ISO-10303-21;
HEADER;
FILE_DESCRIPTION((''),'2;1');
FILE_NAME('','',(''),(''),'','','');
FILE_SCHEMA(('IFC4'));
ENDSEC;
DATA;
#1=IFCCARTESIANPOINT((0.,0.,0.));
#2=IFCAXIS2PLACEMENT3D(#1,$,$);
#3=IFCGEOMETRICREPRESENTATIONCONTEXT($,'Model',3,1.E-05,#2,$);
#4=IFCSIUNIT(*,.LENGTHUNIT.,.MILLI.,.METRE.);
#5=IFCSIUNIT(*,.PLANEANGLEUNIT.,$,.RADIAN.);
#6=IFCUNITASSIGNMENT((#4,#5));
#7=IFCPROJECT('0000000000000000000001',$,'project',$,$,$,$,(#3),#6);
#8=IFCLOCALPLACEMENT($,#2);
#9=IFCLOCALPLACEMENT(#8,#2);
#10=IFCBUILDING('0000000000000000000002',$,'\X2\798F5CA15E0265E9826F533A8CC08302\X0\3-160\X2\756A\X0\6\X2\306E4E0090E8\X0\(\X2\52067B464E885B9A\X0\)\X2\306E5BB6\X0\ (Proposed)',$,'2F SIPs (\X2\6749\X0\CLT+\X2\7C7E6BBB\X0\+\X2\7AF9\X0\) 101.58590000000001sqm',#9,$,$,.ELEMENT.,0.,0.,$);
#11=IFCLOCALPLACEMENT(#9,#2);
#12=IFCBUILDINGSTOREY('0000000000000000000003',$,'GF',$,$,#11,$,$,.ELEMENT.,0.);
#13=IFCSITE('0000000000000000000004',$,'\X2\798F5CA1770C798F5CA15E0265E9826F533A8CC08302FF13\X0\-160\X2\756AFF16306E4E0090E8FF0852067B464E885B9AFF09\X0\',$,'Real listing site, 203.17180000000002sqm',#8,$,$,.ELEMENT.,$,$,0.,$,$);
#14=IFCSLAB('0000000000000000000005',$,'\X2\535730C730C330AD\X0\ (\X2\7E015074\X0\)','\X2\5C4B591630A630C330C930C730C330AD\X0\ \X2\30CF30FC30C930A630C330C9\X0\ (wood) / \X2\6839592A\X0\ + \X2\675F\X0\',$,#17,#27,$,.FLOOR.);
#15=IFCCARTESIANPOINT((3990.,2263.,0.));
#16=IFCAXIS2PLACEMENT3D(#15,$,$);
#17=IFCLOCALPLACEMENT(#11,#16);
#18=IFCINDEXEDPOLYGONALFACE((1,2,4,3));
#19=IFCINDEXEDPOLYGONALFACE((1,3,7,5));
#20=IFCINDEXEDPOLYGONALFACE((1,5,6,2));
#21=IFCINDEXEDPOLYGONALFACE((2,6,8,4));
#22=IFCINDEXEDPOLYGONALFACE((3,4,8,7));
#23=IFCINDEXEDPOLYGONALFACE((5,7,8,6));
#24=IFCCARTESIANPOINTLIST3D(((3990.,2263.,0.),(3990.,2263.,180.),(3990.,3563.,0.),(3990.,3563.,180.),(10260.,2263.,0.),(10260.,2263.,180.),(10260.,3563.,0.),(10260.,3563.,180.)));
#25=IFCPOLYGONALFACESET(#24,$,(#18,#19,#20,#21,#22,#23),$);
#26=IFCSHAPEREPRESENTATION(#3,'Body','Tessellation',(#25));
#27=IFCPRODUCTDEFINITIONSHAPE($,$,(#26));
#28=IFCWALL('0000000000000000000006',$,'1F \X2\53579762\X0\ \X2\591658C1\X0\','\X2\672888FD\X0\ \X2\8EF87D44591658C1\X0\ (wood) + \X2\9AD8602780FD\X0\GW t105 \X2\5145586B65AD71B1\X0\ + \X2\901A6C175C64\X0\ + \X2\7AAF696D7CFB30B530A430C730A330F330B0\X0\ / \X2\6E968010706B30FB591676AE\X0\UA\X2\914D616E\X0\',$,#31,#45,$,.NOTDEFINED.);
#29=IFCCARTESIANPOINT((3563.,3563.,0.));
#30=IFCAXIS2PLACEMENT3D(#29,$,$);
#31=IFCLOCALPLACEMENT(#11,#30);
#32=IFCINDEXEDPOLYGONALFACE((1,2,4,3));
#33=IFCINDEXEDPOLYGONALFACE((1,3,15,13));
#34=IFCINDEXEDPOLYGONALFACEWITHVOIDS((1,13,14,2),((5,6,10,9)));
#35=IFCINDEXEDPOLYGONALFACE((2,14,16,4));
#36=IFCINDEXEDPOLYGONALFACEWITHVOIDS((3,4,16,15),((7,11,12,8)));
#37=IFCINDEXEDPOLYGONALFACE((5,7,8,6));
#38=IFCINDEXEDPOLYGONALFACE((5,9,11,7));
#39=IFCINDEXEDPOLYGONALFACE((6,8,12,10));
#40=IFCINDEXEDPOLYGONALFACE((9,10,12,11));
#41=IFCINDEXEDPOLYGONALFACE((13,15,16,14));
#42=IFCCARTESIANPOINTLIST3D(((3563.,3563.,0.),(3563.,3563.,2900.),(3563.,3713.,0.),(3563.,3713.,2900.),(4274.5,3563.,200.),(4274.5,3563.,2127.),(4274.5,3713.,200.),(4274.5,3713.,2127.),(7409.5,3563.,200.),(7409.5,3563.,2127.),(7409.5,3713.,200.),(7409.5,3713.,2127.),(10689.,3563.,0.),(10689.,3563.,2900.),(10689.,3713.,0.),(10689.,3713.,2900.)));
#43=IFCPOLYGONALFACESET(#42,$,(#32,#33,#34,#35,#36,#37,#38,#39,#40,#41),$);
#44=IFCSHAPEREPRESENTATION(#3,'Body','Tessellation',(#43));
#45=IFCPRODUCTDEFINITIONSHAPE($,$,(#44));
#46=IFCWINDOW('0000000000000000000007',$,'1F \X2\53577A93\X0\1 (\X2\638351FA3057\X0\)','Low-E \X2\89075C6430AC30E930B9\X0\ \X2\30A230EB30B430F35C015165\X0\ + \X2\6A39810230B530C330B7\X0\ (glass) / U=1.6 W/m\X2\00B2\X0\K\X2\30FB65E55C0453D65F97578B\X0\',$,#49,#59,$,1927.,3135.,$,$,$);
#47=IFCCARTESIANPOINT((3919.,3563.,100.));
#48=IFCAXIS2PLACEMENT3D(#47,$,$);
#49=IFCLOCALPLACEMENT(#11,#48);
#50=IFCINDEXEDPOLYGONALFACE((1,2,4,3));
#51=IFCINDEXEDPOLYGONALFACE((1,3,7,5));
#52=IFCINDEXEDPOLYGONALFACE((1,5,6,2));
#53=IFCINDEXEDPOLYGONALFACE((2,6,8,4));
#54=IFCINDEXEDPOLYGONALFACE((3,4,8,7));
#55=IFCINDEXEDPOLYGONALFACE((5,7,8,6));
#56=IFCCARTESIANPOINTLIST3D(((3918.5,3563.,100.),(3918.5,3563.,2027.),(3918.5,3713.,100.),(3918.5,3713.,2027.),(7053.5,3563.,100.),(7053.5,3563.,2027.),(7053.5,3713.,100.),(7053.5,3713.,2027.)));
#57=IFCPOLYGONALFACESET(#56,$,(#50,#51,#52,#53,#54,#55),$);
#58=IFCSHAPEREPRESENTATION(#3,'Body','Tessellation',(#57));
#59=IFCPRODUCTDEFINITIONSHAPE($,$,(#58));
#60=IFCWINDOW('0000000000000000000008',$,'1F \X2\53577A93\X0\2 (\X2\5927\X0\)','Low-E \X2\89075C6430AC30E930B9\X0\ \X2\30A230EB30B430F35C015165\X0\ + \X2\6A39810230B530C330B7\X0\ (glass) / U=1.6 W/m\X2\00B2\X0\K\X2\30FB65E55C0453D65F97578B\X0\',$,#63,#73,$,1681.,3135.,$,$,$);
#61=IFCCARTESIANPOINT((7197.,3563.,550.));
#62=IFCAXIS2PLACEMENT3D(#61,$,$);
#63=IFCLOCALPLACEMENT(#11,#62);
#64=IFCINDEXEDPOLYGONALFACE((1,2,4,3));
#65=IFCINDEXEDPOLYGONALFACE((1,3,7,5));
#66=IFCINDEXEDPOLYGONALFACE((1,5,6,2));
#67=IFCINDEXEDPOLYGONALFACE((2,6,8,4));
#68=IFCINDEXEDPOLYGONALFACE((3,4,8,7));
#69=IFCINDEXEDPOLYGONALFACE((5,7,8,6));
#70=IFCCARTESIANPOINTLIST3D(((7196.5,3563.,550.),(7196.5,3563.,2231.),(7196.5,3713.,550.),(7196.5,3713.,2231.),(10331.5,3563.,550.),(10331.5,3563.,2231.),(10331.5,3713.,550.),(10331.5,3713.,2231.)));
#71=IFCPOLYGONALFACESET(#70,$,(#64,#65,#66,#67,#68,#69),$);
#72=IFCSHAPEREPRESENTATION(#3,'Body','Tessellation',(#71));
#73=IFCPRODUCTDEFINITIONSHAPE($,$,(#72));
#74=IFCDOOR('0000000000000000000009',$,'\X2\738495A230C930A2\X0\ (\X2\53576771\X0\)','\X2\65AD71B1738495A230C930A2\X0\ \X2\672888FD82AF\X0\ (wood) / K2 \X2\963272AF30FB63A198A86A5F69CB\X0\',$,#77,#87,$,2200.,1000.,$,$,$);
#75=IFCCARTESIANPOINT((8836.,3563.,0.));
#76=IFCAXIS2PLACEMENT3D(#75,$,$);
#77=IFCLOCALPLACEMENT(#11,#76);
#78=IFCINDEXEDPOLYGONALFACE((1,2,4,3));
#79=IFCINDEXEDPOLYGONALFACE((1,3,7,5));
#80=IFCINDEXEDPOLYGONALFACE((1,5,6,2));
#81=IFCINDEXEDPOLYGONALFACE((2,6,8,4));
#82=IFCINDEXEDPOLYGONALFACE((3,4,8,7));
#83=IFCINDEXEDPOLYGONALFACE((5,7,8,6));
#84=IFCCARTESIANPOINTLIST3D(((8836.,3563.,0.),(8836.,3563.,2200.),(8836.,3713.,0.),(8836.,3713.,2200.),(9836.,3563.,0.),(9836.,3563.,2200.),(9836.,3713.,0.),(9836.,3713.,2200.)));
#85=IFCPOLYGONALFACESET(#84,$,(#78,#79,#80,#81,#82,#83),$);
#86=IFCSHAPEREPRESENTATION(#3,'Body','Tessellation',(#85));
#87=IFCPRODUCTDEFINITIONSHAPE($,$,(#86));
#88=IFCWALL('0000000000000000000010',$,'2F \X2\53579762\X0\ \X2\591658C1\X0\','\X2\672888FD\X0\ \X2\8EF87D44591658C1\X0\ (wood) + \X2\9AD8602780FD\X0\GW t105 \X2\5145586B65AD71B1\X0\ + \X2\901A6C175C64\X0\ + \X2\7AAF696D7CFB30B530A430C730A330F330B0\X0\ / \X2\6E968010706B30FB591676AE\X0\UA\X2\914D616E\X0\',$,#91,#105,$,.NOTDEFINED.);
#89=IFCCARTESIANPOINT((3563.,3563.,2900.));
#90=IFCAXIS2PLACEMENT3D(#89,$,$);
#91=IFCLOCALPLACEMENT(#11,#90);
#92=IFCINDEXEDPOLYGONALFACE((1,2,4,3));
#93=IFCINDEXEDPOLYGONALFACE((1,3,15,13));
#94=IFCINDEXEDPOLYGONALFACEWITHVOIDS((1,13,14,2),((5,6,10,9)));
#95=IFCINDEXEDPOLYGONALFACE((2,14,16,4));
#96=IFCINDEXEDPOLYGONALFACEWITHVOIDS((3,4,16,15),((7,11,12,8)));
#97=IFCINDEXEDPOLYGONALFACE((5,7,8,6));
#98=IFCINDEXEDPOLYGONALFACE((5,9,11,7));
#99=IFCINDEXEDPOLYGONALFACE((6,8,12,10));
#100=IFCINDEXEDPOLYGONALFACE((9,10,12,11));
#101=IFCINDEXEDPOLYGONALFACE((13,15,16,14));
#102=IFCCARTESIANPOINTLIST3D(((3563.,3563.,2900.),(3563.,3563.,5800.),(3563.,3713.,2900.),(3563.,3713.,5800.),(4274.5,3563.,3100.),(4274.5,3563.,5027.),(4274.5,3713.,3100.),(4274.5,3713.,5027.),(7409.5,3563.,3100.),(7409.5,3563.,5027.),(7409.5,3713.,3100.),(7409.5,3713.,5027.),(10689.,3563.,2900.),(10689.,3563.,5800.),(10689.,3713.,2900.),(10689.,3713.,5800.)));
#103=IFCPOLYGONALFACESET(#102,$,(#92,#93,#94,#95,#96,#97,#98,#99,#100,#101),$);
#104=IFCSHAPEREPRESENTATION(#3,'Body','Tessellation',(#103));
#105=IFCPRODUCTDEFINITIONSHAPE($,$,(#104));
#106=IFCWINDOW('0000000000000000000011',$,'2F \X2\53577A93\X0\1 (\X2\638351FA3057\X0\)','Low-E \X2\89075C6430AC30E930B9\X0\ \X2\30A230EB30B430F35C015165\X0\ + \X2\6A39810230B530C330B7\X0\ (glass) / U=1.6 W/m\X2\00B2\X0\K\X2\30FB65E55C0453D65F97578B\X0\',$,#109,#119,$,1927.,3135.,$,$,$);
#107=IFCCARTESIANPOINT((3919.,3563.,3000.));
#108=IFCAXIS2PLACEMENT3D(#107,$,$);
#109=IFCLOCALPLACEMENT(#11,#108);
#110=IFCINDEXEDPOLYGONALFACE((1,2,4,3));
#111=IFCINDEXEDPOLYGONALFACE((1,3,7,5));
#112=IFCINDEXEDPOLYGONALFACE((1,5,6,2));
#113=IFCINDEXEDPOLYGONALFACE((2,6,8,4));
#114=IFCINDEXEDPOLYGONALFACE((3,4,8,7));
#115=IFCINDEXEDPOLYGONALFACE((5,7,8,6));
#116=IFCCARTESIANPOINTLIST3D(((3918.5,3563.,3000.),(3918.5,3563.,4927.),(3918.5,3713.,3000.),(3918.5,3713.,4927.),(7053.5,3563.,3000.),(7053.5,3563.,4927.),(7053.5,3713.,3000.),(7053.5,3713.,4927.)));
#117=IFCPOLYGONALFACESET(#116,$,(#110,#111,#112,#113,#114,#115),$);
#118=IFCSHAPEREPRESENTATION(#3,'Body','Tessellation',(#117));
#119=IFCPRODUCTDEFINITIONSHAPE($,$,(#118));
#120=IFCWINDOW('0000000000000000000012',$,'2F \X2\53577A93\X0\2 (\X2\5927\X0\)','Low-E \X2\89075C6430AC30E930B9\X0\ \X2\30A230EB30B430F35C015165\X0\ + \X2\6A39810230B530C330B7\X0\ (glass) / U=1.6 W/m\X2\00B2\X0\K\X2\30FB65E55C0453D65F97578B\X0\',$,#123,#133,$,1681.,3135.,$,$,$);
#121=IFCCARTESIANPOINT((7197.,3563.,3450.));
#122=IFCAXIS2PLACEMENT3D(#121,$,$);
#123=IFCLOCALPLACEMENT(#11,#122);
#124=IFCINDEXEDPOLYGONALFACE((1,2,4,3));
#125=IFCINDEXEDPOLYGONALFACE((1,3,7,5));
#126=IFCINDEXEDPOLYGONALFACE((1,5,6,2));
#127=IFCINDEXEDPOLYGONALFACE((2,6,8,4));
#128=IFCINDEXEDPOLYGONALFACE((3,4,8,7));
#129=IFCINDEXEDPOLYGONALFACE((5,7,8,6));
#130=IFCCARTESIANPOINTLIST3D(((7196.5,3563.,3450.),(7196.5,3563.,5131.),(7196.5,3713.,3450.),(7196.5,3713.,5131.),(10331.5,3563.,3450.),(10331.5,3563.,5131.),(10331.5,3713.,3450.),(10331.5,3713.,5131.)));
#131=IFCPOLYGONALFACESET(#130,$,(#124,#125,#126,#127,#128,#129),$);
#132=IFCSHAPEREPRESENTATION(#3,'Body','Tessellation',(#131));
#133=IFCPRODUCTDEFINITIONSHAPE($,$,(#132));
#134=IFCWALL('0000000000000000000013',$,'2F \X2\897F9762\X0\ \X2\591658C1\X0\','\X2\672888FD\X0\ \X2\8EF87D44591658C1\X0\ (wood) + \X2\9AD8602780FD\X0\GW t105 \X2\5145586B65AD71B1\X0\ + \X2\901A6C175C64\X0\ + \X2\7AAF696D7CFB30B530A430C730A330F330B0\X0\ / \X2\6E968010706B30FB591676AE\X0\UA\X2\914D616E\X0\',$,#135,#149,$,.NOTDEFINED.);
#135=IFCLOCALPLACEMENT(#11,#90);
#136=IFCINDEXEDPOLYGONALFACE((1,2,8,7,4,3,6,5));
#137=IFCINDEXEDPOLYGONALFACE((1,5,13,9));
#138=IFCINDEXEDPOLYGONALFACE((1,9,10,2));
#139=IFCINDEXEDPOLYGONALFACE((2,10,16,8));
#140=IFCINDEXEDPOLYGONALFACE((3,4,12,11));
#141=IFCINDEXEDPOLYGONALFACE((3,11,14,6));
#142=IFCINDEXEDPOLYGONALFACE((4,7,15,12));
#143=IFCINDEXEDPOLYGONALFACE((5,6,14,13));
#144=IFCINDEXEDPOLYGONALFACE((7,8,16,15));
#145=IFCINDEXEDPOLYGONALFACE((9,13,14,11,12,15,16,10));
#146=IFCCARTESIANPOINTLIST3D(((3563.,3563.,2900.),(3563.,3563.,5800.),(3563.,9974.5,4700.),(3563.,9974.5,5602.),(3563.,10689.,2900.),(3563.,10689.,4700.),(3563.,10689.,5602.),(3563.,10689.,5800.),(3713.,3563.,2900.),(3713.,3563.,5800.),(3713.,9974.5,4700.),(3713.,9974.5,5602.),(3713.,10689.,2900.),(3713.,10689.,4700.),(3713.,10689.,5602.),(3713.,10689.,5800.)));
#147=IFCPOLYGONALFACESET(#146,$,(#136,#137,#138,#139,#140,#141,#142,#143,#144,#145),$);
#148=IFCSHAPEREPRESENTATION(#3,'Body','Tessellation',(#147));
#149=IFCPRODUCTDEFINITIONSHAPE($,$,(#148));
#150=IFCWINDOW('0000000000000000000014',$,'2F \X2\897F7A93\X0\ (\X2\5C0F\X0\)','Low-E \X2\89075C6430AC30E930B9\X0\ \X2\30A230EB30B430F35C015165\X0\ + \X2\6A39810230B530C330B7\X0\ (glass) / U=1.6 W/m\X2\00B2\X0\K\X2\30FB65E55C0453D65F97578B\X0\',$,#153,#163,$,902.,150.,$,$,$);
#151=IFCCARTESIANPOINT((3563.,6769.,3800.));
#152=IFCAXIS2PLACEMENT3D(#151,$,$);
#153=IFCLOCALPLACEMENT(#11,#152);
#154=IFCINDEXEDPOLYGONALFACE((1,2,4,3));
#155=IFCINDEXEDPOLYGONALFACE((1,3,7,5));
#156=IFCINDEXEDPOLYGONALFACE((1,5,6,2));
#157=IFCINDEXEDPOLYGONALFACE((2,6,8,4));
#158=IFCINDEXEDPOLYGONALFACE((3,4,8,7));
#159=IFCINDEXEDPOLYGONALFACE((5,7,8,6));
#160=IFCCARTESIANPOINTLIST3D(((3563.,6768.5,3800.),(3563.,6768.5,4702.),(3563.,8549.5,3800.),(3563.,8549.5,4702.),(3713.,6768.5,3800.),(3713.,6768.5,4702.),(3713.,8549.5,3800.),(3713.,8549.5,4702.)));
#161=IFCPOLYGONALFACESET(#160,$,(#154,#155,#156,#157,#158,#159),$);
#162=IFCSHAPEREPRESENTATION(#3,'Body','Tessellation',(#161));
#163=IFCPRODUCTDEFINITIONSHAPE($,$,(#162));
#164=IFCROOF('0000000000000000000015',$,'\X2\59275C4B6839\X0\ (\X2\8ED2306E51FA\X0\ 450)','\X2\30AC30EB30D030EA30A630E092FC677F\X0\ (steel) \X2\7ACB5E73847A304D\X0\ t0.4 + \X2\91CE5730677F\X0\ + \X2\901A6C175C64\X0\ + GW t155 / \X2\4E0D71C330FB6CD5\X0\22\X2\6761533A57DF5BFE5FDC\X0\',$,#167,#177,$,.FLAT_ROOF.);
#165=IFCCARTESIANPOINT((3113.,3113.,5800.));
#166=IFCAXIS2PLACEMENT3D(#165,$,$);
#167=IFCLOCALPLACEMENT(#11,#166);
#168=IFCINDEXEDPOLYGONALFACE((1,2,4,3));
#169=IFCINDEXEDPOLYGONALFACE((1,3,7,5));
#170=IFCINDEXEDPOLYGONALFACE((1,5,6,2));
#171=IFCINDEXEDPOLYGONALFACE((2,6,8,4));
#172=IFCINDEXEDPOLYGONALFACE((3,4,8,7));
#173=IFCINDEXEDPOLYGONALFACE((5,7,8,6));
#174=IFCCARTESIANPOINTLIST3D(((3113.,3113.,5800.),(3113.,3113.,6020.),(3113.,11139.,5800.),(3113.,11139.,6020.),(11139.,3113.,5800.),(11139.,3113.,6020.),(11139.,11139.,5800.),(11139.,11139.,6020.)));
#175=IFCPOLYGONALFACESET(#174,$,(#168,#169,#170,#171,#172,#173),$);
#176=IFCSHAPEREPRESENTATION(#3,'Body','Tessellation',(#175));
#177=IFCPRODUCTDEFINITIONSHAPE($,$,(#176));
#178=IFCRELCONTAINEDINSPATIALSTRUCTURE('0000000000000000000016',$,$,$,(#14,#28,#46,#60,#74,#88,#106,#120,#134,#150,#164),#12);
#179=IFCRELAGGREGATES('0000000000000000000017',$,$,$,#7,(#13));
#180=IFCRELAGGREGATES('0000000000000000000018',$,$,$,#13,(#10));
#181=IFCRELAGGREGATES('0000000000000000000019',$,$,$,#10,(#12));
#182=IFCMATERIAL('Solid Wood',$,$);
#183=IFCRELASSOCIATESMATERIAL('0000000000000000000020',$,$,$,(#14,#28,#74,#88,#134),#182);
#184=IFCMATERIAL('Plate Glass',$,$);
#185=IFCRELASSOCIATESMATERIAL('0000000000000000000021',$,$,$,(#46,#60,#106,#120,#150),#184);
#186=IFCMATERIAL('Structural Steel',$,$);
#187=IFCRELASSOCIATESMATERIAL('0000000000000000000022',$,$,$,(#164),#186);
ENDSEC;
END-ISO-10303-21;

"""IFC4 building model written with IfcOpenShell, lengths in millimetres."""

from ifc_helpers import new_model, si_unit, frame, frame_2d, origin, place, context, project, spatial, rectangle, extrude, material, element, fill, save


model = new_model("IFC4")

# Units and contexts
model_context = context("Model", 3, precision=1e-05, world=origin())
ifc_project = project(units=[si_unit("LENGTHUNIT", "METRE", prefix="MILLI"), si_unit("PLANEANGLEUNIT", "RADIAN")], contexts=[model_context])

# Site, building, storey
site_placement = place(None, origin())
site = spatial("IfcSite", under=ifc_project, at=site_placement, Name="福岡県福岡市早良区賀茂３-160番６の一部（分筆予定）", ObjectType="Real listing site, 203.17180000000002sqm", CompositionType="ELEMENT", RefElevation=0.0)
building_placement = place(site_placement, origin())
building = spatial("IfcBuilding", under=site, at=building_placement, Name="福岡市早良区賀茂3-160番6の一部(分筆予定)の家 (Proposed)", ObjectType="2F SIPs (杉CLT+籾殻+竹) 101.58590000000001sqm", CompositionType="ELEMENT", ElevationOfRefHeight=0.0, ElevationOfTerrain=0.0)
storey_placement = place(building_placement, origin())
storey = spatial("IfcBuildingStorey", under=building, at=storey_placement, Name="GF", CompositionType="ELEMENT", Elevation=0.0)

# Slab
ifc_material_1 = material(Name="Solid Wood")
slab_1_placement = place(storey_placement, frame((3990.0, 2263.0, 0.0)))
element("IfcSlab", 1, at=slab_1_placement, inside=storey, material=ifc_material_1, Name="南デッキ (縁側)", Description="屋外ウッドデッキ ハードウッド (wood) / 根太 + 束", PredefinedType="FLOOR", context=model_context, shape_type="SweptSolid", body=[
    extrude(rectangle(XDim=6270.0, YDim=1300.0, at=frame_2d((3135.0, 650.0))), frame((3990.0, 2263.0, 0.0)), (0.0, 0.0, 1.0), 180.0),
])

# Wall, openings, windows, door
wall_1_placement = place(storey_placement, frame((3563.0, 3563.0, 0.0)))
wall_1 = element("IfcWall", 2, at=wall_1_placement, inside=storey, material=ifc_material_1, Name="1F 南面 外壁", Description="木製 軸組外壁 (wood) + 高性能GW t105 充填断熱 + 通気層 + 窯業系サイディング / 準耐火・外皮UA配慮", PredefinedType="NOTDEFINED", context=model_context, shape_type="SweptSolid", body=[
    extrude(rectangle(XDim=7126.0, YDim=150.0, at=frame_2d((3563.0, 75.0))), frame((3563.0, 3563.0, 0.0)), (0.0, 0.0, 1.0), 2900.0),
])
opening_1_placement = place(storey_placement, frame((3919.0, 3563.0, 100.0)))
opening_1 = element("IfcOpeningElement", 3, at=opening_1_placement, cuts=wall_1, PredefinedType="NOTDEFINED", context=model_context, shape_type="SweptSolid", body=[
    extrude(rectangle(XDim=3135.0, YDim=150.0, at=frame_2d((1567.0, 75.0))), frame((3919.0, 3563.0, 100.0)), (0.0, 0.0, 1.0), 1927.0),
])
opening_2_placement = place(storey_placement, frame((7197.0, 3563.0, 550.0)))
opening_2 = element("IfcOpeningElement", 4, at=opening_2_placement, cuts=wall_1, PredefinedType="NOTDEFINED", context=model_context, shape_type="SweptSolid", body=[
    extrude(rectangle(XDim=3135.0, YDim=150.0, at=frame_2d((1567.0, 75.0))), frame((7197.0, 3563.0, 550.0)), (0.0, 0.0, 1.0), 1681.0),
])
opening_3_placement = place(storey_placement, frame((8836.0, 3563.0, 0.0)))
opening_3 = element("IfcOpeningElement", 5, at=opening_3_placement, cuts=wall_1, PredefinedType="NOTDEFINED", context=model_context, shape_type="SweptSolid", body=[
    extrude(rectangle(XDim=1000.0, YDim=150.0, at=frame_2d((500.0, 75.0))), frame((8836.0, 3563.0, 0.0)), (0.0, 0.0, 1.0), 2200.0),
])
ifc_material_2 = material(Name="Plate Glass")
window_1_placement = place(storey_placement, frame((3919.0, 3563.0, 100.0)))
window_1 = element("IfcWindow", 6, at=window_1_placement, inside=storey, material=ifc_material_2, Name="1F 南窓1 (掃出し)", Description="Low-E 複層ガラス アルゴン封入 + 樹脂サッシ (glass) / U=1.6 W/m²K・日射取得型", OverallHeight=1927.0, OverallWidth=3135.0, context=model_context, shape_type="SweptSolid", body=[
    extrude(rectangle(XDim=3135.0, YDim=150.0, at=frame_2d((1567.0, 75.0))), frame((3919.0, 3563.0, 100.0)), (0.0, 0.0, 1.0), 1927.0),
])
fill(opening_1, window_1)
window_2_placement = place(storey_placement, frame((7197.0, 3563.0, 550.0)))
window_2 = element("IfcWindow", 7, at=window_2_placement, inside=storey, material=ifc_material_2, Name="1F 南窓2 (大)", Description="Low-E 複層ガラス アルゴン封入 + 樹脂サッシ (glass) / U=1.6 W/m²K・日射取得型", OverallHeight=1681.0, OverallWidth=3135.0, context=model_context, shape_type="SweptSolid", body=[
    extrude(rectangle(XDim=3135.0, YDim=150.0, at=frame_2d((1567.0, 75.0))), frame((7197.0, 3563.0, 550.0)), (0.0, 0.0, 1.0), 1681.0),
])
fill(opening_2, window_2)
door_placement = place(storey_placement, frame((8836.0, 3563.0, 0.0)))
door = element("IfcDoor", 8, at=door_placement, inside=storey, material=ifc_material_1, Name="玄関ドア (南東)", Description="断熱玄関ドア 木製芯 (wood) / K2 防犯・採風機構", OverallHeight=2200.0, OverallWidth=1000.0, context=model_context, shape_type="SweptSolid", body=[
    extrude(rectangle(XDim=1000.0, YDim=150.0, at=frame_2d((500.0, 75.0))), frame((8836.0, 3563.0, 0.0)), (0.0, 0.0, 1.0), 2200.0),
])
fill(opening_3, door)

# Wall, openings, windows
wall_2_placement = place(storey_placement, frame((3563.0, 3563.0, 2900.0)))
wall_2 = element("IfcWall", 9, at=wall_2_placement, inside=storey, material=ifc_material_1, Name="2F 南面 外壁", Description="木製 軸組外壁 (wood) + 高性能GW t105 充填断熱 + 通気層 + 窯業系サイディング / 準耐火・外皮UA配慮", PredefinedType="NOTDEFINED", context=model_context, shape_type="SweptSolid", body=[
    extrude(rectangle(XDim=7126.0, YDim=150.0, at=frame_2d((3563.0, 75.0))), frame((3563.0, 3563.0, 2900.0)), (0.0, 0.0, 1.0), 2900.0),
])
opening_4_placement = place(storey_placement, frame((3919.0, 3563.0, 3000.0)))
opening_4 = element("IfcOpeningElement", 10, at=opening_4_placement, cuts=wall_2, PredefinedType="NOTDEFINED", context=model_context, shape_type="SweptSolid", body=[
    extrude(rectangle(XDim=3135.0, YDim=150.0, at=frame_2d((1567.0, 75.0))), frame((3919.0, 3563.0, 3000.0)), (0.0, 0.0, 1.0), 1927.0),
])
opening_5_placement = place(storey_placement, frame((7197.0, 3563.0, 3450.0)))
opening_5 = element("IfcOpeningElement", 11, at=opening_5_placement, cuts=wall_2, PredefinedType="NOTDEFINED", context=model_context, shape_type="SweptSolid", body=[
    extrude(rectangle(XDim=3135.0, YDim=150.0, at=frame_2d((1567.0, 75.0))), frame((7197.0, 3563.0, 3450.0)), (0.0, 0.0, 1.0), 1681.0),
])
window_3_placement = place(storey_placement, frame((3919.0, 3563.0, 3000.0)))
window_3 = element("IfcWindow", 12, at=window_3_placement, inside=storey, material=ifc_material_2, Name="2F 南窓1 (掃出し)", Description="Low-E 複層ガラス アルゴン封入 + 樹脂サッシ (glass) / U=1.6 W/m²K・日射取得型", OverallHeight=1927.0, OverallWidth=3135.0, context=model_context, shape_type="SweptSolid", body=[
    extrude(rectangle(XDim=3135.0, YDim=150.0, at=frame_2d((1567.0, 75.0))), frame((3919.0, 3563.0, 3000.0)), (0.0, 0.0, 1.0), 1927.0),
])
fill(opening_4, window_3)
window_4_placement = place(storey_placement, frame((7197.0, 3563.0, 3450.0)))
window_4 = element("IfcWindow", 13, at=window_4_placement, inside=storey, material=ifc_material_2, Name="2F 南窓2 (大)", Description="Low-E 複層ガラス アルゴン封入 + 樹脂サッシ (glass) / U=1.6 W/m²K・日射取得型", OverallHeight=1681.0, OverallWidth=3135.0, context=model_context, shape_type="SweptSolid", body=[
    extrude(rectangle(XDim=3135.0, YDim=150.0, at=frame_2d((1567.0, 75.0))), frame((7197.0, 3563.0, 3450.0)), (0.0, 0.0, 1.0), 1681.0),
])
fill(opening_5, window_4)

# Wall, opening, window
wall_3_placement = place(storey_placement, frame((3563.0, 3563.0, 2900.0)))
wall_3 = element("IfcWall", 14, at=wall_3_placement, inside=storey, material=ifc_material_1, Name="2F 西面 外壁", Description="木製 軸組外壁 (wood) + 高性能GW t105 充填断熱 + 通気層 + 窯業系サイディング / 準耐火・外皮UA配慮", PredefinedType="NOTDEFINED", context=model_context, shape_type="SweptSolid", body=[
    extrude(rectangle(XDim=150.0, YDim=7126.0, at=frame_2d((75.0, 3563.0))), frame((3563.0, 3563.0, 2900.0)), (0.0, 0.0, 1.0), 2900.0),
])
opening_6_placement = place(storey_placement, frame((3563.0, 6769.0, 3800.0)))
opening_6 = element("IfcOpeningElement", 15, at=opening_6_placement, cuts=wall_3, PredefinedType="NOTDEFINED", context=model_context, shape_type="SweptSolid", body=[
    extrude(rectangle(XDim=150.0, YDim=1781.0, at=frame_2d((75.0, 890.0))), frame((3563.0, 6769.0, 3800.0)), (0.0, 0.0, 1.0), 902.0),
])
window_5_placement = place(storey_placement, frame((3563.0, 6769.0, 3800.0)))
window_5 = element("IfcWindow", 16, at=window_5_placement, inside=storey, material=ifc_material_2, Name="2F 西窓 (小)", Description="Low-E 複層ガラス アルゴン封入 + 樹脂サッシ (glass) / U=1.6 W/m²K・日射取得型", OverallHeight=902.0, OverallWidth=150.0, context=model_context, shape_type="SweptSolid", body=[
    extrude(rectangle(XDim=150.0, YDim=1781.0, at=frame_2d((75.0, 890.0))), frame((3563.0, 6769.0, 3800.0)), (0.0, 0.0, 1.0), 902.0),
])
fill(opening_6, window_5)

# Roof
ifc_material_3 = material(Name="Structural Steel")
roof_placement = place(storey_placement, frame((3113.0, 3113.0, 5800.0)))
element("IfcRoof", 17, at=roof_placement, inside=storey, material=ifc_material_3, Name="大屋根 (軒の出 450)", Description="ガルバリウム鋼板 (steel) 立平葺き t0.4 + 野地板 + 通気層 + GW t155 / 不燃・法22条区域対応", PredefinedType="FLAT_ROOF", context=model_context, shape_type="SweptSolid", body=[
    extrude(rectangle(XDim=8026.0, YDim=8026.0, at=frame_2d((4013.0, 4013.0))), frame((3113.0, 3113.0, 5800.0)), (0.0, 0.0, 1.0), 220.0),
])

save(model, "model.ifc")
